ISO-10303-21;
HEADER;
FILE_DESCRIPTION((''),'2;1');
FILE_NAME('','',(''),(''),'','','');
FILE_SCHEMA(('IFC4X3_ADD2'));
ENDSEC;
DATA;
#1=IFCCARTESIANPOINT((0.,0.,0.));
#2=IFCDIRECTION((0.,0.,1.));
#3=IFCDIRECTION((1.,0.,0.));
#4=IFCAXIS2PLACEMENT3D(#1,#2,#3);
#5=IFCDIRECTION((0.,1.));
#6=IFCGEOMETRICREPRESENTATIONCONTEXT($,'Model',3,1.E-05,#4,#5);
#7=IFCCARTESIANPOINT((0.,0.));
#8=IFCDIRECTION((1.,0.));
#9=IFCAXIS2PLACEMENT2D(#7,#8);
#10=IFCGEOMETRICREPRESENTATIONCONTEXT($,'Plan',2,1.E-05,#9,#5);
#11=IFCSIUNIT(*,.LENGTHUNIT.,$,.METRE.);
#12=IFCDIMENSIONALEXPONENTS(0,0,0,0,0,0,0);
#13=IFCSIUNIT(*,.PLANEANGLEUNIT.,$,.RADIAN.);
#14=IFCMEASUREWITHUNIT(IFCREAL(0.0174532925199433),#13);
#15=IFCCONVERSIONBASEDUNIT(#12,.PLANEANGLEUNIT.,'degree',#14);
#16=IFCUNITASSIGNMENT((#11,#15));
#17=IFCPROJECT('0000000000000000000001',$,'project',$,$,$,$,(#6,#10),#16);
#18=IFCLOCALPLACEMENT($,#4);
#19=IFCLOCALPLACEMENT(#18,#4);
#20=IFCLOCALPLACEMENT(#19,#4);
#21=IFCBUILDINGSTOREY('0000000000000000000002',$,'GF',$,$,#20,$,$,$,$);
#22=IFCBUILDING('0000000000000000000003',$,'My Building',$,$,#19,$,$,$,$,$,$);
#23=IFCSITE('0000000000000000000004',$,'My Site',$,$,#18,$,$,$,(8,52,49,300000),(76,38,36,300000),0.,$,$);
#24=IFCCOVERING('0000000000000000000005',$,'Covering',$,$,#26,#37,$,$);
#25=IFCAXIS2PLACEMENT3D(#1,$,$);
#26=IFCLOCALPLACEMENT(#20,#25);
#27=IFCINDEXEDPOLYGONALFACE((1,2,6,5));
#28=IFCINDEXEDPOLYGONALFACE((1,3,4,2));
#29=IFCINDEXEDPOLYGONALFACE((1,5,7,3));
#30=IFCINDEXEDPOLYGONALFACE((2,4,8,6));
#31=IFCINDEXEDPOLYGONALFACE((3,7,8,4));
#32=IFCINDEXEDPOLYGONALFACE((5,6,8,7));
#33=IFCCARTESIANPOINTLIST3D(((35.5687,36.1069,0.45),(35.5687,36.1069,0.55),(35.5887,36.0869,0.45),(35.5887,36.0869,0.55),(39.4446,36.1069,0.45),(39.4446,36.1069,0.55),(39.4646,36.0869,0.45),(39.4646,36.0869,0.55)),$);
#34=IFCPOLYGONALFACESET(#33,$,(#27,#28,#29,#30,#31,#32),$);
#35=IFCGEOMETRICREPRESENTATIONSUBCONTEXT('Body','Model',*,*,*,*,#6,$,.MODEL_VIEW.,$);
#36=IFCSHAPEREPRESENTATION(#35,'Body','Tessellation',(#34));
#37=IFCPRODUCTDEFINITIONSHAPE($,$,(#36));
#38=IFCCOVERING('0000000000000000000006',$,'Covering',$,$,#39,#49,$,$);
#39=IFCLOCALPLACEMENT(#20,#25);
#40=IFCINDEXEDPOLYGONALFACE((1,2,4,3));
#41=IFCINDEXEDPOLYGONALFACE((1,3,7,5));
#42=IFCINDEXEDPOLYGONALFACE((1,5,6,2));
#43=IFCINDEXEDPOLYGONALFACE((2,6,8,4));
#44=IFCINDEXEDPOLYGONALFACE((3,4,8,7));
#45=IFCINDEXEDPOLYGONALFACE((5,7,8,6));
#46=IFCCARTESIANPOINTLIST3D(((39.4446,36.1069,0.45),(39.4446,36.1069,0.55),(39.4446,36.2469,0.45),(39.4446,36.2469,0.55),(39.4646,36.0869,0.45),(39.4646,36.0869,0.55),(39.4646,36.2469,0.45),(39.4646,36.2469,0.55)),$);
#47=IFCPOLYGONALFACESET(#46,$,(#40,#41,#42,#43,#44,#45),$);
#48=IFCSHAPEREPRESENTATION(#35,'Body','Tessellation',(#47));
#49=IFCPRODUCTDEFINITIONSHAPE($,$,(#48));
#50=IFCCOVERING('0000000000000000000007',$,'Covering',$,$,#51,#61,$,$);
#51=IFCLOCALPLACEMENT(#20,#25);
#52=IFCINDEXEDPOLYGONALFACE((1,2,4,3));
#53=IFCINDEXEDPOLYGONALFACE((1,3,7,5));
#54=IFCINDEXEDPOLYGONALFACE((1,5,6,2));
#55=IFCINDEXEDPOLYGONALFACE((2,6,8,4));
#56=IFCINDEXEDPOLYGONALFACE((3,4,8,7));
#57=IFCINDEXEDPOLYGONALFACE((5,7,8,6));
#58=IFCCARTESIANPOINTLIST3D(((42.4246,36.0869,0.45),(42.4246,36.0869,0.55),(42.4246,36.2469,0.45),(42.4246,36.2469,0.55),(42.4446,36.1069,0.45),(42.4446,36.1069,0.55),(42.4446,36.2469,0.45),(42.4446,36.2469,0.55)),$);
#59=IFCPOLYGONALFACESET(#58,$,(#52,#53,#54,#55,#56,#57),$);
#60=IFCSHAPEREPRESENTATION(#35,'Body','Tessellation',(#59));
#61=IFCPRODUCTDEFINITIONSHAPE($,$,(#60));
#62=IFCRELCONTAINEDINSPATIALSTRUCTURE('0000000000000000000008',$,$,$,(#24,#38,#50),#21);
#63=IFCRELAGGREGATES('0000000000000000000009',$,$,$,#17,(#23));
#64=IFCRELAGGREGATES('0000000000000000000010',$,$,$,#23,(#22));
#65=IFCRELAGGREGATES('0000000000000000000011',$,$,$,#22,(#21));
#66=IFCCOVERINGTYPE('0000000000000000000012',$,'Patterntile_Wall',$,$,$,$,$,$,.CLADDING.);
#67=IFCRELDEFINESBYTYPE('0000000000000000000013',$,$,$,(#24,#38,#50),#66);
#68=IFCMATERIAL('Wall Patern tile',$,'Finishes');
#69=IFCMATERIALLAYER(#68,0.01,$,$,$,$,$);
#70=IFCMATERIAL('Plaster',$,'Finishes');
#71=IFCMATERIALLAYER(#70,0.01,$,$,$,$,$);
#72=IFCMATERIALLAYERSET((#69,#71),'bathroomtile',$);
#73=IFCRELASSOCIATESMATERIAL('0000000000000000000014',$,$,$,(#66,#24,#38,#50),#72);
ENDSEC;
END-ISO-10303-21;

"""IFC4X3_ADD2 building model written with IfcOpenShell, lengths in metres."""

from ifc_helpers import new_model, entity, si_unit, converted_unit, direction, frame, origin_with_axes, origin_2d_with_axis, place, context, subcontext, project, spatial, line, indexed_curve, outline, extrude, material, layer, layer_set, layer_usage, type_object, element, save


model = new_model("IFC4X3_ADD2")

# Units and contexts
model_context = context("Model", 3, precision=1e-05, world=origin_with_axes(), true_north=direction((0.0, 1.0)))
plan_context = context("Plan", 2, precision=1e-05, world=origin_2d_with_axis(), true_north=direction((0.0, 1.0)))
body_context_1 = subcontext(model_context, "Body", "Model", "MODEL_VIEW")
ifc_project = project(units=[si_unit("LENGTHUNIT", "METRE"), converted_unit("PLANEANGLEUNIT", "degree", entity("IfcReal", 0.0174532925199433), si_unit("PLANEANGLEUNIT", "RADIAN"), dimensions=[0, 0, 0, 0, 0, 0, 0])], contexts=[model_context, plan_context])

# Site, building, storey
site_placement = place(None, origin_with_axes())
site = spatial("IfcSite", under=ifc_project, at=site_placement, Name="My Site", RefLatitude=(8, 52, 49, 300000), RefLongitude=(76, 38, 36, 300000), RefElevation=0.0)
building_placement = place(site_placement, origin_with_axes())
building = spatial("IfcBuilding", under=site, at=building_placement, Name="My Building")
storey_placement = place(building_placement, origin_with_axes())
storey = spatial("IfcBuildingStorey", under=building, at=storey_placement, Name="GF")

# Coverings
ifc_material_1 = material(Name="Wall Patern tile", Category="Finishes")
ifc_layer_1 = layer(ifc_material_1, 0.01)
ifc_material_2 = material(Name="Plaster", Category="Finishes")
ifc_layer_2 = layer(ifc_material_2, 0.01)
ifc_layer_set_1 = layer_set([ifc_layer_1, ifc_layer_2], Name="bathroomtile")
covering_type = type_object("IfcCoveringType", Name="Patterntile_Wall", PredefinedType="CLADDING", material=ifc_layer_set_1)
ifc_layer_usage_1 = layer_usage(ifc_layer_set_1, "AXIS2", "NEGATIVE", 0.0)
covering_1_placement = place(storey_placement, frame((39.4646, 36.0869, 0.45), z_axis=(0.0, 0.0, 1.0), x_axis=(-1.0, 0.000001, 0.0)))
element("IfcCovering", 1, at=covering_1_placement, inside=storey, type_object=covering_type, material=ifc_layer_usage_1, Name="Covering", context=body_context_1, shape_type="SweptSolid", body=[
    extrude(outline(indexed_curve([(0.02, -0.02), (0.0, 0.0), (3.8758, 0.0), (3.8958, -0.02)], segments=[line(1, 2, 3, 4, 1)])), origin_with_axes(), (0.0, 0.0, 1.0), 0.1),
])
ifc_layer_usage_2 = layer_usage(ifc_layer_set_1, "AXIS2", "POSITIVE", 0.0)
covering_2_placement = place(storey_placement, frame((39.4646, 36.0869, 0.45), z_axis=(0.0, 0.0, 1.0), x_axis=(0.000001, 1.0, 0.0)))
element("IfcCovering", 2, at=covering_2_placement, inside=storey, type_object=covering_type, material=ifc_layer_usage_2, Name="Covering", context=body_context_1, shape_type="SweptSolid", body=[
    extrude(outline(indexed_curve([(0.0, 0.0), (0.02, 0.02), (0.16, 0.02), (0.16, 0.0)], segments=[line(1, 2, 3, 4, 1)])), origin_with_axes(), (0.0, 0.0, 1.0), 0.1),
])
ifc_layer_usage_3 = layer_usage(ifc_layer_set_1, "AXIS2", "NEGATIVE", 0.0)
covering_3_placement = place(storey_placement, frame((42.4246, 36.0869, 0.45), z_axis=(0.0, 0.0, 1.0), x_axis=(0.000001, 1.0, 0.0)))
element("IfcCovering", 3, at=covering_3_placement, inside=storey, type_object=covering_type, material=ifc_layer_usage_3, Name="Covering", context=body_context_1, shape_type="SweptSolid", body=[
    extrude(outline(indexed_curve([(0.02, -0.02), (0.0, 0.0), (0.16, 0.0), (0.16, -0.02)], segments=[line(1, 2, 3, 4, 1)])), origin_with_axes(), (0.0, 0.0, 1.0), 0.1),
])

save(model, "model.ifc")
